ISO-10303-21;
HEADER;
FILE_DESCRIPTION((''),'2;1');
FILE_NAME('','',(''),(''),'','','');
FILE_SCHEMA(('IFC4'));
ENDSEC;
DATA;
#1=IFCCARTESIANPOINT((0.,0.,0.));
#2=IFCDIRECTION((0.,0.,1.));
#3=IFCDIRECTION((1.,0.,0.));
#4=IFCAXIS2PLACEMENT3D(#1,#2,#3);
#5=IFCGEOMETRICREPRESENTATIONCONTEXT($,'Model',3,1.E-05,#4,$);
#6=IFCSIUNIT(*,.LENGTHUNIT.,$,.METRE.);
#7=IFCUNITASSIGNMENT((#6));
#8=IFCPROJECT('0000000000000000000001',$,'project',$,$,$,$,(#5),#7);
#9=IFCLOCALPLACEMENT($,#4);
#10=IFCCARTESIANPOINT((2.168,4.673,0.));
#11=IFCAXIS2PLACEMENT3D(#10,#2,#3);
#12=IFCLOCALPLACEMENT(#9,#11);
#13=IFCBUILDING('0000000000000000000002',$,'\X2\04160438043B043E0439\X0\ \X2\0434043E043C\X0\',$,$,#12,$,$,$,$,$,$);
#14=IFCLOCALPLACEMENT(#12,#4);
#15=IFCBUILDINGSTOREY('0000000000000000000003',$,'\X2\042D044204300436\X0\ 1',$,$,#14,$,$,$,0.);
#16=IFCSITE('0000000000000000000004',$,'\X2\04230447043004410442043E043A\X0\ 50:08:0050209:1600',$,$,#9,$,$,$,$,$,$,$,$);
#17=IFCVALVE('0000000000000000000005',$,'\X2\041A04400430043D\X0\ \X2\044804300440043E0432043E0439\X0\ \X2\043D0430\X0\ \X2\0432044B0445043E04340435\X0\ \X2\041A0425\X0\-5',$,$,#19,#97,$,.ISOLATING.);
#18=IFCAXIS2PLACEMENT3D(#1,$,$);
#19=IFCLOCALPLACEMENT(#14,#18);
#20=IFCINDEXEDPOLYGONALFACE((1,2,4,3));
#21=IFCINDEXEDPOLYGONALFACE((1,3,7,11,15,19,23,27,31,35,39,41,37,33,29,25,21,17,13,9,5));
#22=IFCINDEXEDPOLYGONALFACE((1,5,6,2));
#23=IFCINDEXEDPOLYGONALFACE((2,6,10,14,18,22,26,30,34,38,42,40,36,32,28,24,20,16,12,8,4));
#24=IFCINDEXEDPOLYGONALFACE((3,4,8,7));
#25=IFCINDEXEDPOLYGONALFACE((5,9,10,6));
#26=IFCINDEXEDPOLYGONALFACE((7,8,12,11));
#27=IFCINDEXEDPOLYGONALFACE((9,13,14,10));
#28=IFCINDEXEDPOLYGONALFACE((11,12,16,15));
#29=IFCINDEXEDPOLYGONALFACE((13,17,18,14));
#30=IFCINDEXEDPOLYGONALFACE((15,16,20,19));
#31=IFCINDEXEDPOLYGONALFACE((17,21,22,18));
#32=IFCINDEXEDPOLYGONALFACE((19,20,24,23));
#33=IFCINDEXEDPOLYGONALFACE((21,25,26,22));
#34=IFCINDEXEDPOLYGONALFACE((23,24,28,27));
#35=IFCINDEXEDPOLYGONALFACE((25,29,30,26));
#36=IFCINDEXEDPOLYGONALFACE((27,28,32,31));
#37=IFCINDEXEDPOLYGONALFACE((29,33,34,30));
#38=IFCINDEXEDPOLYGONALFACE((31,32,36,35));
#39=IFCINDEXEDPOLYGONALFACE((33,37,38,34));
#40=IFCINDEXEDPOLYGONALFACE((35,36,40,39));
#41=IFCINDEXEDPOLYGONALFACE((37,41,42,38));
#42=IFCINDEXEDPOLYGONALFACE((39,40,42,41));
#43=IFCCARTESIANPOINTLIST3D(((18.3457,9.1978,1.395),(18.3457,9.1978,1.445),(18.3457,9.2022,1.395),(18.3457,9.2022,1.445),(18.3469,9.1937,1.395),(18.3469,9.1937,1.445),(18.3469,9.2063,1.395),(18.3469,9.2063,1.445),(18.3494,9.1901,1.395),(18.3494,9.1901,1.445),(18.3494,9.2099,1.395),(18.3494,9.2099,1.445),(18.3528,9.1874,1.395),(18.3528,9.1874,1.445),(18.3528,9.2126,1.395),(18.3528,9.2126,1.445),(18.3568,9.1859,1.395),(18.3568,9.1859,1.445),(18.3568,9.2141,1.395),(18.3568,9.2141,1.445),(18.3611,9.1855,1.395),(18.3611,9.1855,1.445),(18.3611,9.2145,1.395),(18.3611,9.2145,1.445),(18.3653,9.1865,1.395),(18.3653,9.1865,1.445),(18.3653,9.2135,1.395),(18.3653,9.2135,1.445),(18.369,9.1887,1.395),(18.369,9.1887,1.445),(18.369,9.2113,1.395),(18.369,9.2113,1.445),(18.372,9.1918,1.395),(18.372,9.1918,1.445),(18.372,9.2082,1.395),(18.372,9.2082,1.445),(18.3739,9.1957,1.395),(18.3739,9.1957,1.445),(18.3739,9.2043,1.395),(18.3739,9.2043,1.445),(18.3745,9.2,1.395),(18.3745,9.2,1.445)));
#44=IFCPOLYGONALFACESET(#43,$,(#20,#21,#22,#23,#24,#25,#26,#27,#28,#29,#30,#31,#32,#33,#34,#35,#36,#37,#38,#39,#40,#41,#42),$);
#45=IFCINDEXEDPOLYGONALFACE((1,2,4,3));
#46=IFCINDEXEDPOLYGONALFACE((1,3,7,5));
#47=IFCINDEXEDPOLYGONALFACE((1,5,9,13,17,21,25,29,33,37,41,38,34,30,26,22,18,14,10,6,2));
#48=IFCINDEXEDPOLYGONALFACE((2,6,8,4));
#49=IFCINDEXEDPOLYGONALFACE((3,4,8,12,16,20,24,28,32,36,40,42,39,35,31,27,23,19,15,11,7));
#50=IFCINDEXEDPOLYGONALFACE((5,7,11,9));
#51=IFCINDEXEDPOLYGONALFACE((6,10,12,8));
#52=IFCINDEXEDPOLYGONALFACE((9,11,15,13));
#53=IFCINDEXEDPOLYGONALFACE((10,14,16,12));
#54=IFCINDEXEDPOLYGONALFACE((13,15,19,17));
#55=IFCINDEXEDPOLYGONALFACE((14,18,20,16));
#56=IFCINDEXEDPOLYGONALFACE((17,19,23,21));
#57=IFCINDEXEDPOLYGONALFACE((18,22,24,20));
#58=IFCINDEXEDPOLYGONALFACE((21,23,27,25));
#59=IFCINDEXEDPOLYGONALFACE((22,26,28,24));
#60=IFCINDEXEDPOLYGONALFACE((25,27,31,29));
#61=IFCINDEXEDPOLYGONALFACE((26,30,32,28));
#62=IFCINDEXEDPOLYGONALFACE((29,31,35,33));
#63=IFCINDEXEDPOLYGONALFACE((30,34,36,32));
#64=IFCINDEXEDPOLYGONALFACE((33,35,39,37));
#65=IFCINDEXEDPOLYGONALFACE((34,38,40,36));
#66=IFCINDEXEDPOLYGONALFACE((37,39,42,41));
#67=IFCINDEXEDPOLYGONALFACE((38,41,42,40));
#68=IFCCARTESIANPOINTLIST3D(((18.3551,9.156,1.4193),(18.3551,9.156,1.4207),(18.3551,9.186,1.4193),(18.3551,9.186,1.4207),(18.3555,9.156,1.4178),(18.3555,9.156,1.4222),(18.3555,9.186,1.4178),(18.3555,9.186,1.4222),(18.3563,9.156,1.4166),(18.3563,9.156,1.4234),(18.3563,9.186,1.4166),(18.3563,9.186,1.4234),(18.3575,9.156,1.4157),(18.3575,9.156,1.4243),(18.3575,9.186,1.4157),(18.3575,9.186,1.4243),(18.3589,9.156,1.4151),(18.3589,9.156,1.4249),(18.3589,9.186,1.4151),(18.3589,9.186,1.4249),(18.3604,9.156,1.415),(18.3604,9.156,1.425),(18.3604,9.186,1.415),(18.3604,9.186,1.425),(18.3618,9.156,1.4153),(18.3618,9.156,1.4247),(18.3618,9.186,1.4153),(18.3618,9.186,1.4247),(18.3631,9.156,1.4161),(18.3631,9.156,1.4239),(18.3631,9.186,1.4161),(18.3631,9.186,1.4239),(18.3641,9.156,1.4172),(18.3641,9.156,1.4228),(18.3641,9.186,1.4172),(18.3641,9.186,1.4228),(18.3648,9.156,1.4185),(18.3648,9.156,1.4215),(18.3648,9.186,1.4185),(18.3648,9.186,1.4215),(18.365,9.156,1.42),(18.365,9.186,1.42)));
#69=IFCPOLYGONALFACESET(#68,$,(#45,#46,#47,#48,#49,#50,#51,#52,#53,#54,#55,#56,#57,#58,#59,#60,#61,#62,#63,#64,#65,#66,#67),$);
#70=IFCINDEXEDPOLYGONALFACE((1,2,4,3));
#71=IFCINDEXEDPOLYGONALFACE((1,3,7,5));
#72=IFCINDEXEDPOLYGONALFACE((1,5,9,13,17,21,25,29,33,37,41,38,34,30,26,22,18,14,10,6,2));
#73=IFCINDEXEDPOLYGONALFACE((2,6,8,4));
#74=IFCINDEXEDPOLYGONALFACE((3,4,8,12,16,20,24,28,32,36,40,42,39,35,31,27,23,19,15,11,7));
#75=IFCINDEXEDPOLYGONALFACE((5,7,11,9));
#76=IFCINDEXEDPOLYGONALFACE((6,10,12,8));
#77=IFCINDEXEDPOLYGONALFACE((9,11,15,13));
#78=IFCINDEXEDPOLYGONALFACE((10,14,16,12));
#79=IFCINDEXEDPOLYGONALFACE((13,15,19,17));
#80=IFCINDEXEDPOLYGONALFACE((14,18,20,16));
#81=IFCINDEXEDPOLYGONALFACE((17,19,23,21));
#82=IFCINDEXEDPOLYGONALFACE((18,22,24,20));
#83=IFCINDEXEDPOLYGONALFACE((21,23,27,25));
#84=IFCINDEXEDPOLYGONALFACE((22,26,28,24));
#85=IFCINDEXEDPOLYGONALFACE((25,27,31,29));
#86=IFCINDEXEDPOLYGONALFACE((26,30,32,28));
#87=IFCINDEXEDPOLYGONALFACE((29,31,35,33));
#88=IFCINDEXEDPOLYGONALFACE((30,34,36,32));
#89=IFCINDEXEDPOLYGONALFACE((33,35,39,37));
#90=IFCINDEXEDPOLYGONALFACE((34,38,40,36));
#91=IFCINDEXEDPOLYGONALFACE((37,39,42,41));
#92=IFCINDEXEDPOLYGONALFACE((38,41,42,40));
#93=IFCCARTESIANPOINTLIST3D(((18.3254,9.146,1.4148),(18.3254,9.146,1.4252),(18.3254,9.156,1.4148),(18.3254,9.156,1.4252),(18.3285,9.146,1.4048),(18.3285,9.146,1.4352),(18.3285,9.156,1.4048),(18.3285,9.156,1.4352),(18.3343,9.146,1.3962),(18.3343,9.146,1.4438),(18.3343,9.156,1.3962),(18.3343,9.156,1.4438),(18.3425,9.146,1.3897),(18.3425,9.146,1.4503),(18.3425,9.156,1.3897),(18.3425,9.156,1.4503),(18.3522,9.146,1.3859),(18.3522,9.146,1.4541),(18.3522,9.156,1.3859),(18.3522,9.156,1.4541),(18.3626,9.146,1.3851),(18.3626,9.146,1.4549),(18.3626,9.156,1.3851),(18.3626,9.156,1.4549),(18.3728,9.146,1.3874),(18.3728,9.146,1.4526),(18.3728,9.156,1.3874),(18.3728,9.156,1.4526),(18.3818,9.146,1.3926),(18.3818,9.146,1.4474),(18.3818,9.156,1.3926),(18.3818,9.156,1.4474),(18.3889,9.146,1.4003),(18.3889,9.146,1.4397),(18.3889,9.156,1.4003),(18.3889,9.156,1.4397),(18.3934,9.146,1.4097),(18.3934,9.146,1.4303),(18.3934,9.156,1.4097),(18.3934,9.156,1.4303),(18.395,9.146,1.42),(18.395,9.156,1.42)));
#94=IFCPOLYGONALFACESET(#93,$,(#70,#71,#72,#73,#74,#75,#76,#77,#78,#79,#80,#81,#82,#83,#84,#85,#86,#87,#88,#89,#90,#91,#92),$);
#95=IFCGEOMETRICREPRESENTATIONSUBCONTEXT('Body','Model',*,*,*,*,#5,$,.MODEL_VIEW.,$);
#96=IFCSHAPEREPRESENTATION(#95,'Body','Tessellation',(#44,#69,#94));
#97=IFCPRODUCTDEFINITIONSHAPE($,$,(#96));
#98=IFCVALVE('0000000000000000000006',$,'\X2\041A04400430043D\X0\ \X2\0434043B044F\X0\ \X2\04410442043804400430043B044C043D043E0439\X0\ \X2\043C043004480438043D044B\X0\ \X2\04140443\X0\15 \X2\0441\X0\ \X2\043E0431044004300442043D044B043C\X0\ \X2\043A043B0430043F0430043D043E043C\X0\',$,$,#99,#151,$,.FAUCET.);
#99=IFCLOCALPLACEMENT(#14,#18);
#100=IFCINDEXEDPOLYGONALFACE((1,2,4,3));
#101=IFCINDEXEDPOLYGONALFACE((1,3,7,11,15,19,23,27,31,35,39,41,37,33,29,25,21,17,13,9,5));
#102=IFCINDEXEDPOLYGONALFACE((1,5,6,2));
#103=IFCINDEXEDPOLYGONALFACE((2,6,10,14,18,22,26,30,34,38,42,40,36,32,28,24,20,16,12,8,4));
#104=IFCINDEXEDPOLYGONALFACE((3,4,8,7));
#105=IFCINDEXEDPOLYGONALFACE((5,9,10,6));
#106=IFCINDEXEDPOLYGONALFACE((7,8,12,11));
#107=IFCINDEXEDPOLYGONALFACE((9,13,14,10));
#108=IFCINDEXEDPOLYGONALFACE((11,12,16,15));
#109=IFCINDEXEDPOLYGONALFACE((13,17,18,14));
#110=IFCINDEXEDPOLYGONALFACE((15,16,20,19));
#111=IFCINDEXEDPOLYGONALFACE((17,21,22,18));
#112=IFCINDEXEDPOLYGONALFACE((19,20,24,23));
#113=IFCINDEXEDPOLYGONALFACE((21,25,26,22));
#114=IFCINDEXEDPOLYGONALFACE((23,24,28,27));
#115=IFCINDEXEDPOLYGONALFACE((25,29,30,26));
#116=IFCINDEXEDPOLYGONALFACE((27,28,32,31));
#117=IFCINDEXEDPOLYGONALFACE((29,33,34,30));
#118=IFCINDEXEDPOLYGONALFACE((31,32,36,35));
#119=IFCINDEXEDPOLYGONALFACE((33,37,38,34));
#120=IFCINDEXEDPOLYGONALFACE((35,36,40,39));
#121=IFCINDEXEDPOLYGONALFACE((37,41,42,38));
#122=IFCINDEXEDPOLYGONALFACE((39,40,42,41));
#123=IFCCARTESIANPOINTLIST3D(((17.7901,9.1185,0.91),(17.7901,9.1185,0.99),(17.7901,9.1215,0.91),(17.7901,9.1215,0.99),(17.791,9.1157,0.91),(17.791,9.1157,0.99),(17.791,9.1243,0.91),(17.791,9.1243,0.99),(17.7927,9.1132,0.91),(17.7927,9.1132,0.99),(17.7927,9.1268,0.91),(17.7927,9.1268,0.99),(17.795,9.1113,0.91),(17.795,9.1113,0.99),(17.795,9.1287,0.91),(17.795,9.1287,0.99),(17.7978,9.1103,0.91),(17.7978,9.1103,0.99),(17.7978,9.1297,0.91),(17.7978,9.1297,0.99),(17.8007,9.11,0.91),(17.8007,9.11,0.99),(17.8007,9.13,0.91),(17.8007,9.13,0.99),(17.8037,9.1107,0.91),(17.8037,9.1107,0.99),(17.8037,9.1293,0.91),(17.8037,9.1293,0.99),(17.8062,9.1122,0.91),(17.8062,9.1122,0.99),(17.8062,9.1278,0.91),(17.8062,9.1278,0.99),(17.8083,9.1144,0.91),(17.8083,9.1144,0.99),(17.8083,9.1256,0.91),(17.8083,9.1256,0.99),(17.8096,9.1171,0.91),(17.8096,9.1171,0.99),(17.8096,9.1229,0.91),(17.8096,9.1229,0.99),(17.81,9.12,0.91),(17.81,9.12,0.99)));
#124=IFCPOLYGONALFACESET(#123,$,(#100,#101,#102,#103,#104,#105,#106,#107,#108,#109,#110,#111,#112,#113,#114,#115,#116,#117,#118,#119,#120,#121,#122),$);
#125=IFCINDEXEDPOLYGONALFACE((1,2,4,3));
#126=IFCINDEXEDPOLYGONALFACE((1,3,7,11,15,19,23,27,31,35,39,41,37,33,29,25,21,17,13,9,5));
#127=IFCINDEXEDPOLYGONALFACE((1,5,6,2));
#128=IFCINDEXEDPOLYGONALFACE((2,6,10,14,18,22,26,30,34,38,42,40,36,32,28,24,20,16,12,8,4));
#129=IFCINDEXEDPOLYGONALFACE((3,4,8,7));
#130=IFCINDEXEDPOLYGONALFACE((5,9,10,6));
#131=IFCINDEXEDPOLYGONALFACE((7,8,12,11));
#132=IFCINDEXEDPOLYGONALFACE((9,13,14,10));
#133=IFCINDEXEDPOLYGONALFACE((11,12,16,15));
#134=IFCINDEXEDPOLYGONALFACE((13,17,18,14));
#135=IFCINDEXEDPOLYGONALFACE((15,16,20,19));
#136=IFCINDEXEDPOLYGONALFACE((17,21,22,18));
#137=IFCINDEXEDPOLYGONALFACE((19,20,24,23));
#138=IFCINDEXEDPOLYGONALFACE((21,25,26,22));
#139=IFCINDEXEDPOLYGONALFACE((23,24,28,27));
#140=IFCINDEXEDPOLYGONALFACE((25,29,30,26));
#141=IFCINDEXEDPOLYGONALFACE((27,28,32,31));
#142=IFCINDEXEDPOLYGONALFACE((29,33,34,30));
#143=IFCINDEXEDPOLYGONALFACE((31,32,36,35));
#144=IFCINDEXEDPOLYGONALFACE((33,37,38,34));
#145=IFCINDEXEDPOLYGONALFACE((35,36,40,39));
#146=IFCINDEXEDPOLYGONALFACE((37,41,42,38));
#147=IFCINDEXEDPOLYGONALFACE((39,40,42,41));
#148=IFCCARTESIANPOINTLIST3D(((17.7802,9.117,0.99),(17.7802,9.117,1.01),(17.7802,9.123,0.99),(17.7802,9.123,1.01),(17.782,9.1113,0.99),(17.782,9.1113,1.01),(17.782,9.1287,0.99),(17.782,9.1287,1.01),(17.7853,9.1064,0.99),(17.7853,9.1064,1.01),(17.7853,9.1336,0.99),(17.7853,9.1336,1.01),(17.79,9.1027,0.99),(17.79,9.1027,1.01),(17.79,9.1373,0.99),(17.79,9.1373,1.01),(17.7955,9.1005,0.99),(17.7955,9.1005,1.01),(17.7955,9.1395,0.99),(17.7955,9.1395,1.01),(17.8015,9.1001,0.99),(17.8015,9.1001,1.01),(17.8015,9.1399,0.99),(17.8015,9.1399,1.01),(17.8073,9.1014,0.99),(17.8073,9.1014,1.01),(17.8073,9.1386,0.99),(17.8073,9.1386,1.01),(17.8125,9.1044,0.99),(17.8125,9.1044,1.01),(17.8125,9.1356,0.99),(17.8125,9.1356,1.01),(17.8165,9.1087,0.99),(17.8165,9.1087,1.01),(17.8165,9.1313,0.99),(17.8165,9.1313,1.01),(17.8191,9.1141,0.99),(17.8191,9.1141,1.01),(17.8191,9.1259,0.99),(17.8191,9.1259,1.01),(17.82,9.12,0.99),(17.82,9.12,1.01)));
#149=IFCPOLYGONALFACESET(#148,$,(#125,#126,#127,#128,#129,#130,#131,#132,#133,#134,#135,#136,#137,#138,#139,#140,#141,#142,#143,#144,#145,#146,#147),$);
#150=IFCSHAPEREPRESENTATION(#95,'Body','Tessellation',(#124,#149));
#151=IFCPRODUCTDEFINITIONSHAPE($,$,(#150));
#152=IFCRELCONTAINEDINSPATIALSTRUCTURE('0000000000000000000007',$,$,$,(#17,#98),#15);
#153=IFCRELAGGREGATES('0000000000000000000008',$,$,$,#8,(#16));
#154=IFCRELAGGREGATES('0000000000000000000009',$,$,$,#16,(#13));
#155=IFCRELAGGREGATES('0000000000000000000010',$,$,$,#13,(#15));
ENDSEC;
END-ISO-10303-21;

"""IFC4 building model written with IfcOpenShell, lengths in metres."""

from ifc_helpers import new_model, si_unit, frame, origin_with_axes, origin_2d, place, context, subcontext, project, spatial, circle, extrude, element, save


model = new_model("IFC4")

# Units and contexts
model_context = context("Model", 3, precision=1e-05, world=origin_with_axes())
body_context = subcontext(model_context, "Body", "Model", "MODEL_VIEW")
ifc_project = project(units=[si_unit("LENGTHUNIT", "METRE")], contexts=[model_context])

# Site, building, storey
site_placement = place(None, origin_with_axes())
site = spatial("IfcSite", under=ifc_project, at=site_placement, Name="Участок 50:08:0050209:1600")
building_placement = place(site_placement, frame((2.168, 4.673, 0.0), z_axis=(0.0, 0.0, 1.0), x_axis=(1.0, 0.0, 0.0)))
building = spatial("IfcBuilding", under=site, at=building_placement, Name="Жилой дом")
storey_placement = place(building_placement, origin_with_axes())
storey = spatial("IfcBuildingStorey", under=building, at=storey_placement, Name="Этаж 1", Elevation=0.0)

# Valves
valve_1_placement = place(storey_placement, origin_with_axes())
element("IfcValve", 1, at=valve_1_placement, inside=storey, Name="Кран шаровой на выходе КХ-5", PredefinedType="ISOLATING", context=body_context, shape_type="SweptSolid", body=[
    extrude(circle(Radius=0.0145, at=origin_2d()), frame((18.36, 9.2, 1.395), z_axis=(0.0, 0.0, 1.0), x_axis=(1.0, 0.0, 0.0)), (0.0, 0.0, 1.0), 0.05),
    extrude(circle(Radius=0.005, at=origin_2d()), frame((18.36, 9.186, 1.42), z_axis=(0.0, -1.0, 0.0), x_axis=(1.0, 0.0, 0.0)), (0.0, 0.0, 1.0), 0.03),
    extrude(circle(Radius=0.035, at=origin_2d()), frame((18.36, 9.156, 1.42), z_axis=(0.0, -1.0, 0.0), x_axis=(1.0, 0.0, 0.0)), (0.0, 0.0, 1.0), 0.01),
])
valve_2_placement = place(storey_placement, origin_with_axes())
element("IfcValve", 2, at=valve_2_placement, inside=storey, Name="Кран для стиральной машины Ду15 с обратным клапаном", PredefinedType="FAUCET", context=body_context, shape_type="SweptSolid", body=[
    extrude(circle(Radius=0.01, at=origin_2d()), frame((17.8, 9.12, 0.91), z_axis=(0.0, 0.0, 1.0), x_axis=(1.0, 0.0, 0.0)), (0.0, 0.0, 1.0), 0.08),
    extrude(circle(Radius=0.02, at=origin_2d()), frame((17.8, 9.12, 0.99), z_axis=(0.0, 0.0, 1.0), x_axis=(1.0, 0.0, 0.0)), (0.0, 0.0, 1.0), 0.02),
])

save(model, "model.ifc")
